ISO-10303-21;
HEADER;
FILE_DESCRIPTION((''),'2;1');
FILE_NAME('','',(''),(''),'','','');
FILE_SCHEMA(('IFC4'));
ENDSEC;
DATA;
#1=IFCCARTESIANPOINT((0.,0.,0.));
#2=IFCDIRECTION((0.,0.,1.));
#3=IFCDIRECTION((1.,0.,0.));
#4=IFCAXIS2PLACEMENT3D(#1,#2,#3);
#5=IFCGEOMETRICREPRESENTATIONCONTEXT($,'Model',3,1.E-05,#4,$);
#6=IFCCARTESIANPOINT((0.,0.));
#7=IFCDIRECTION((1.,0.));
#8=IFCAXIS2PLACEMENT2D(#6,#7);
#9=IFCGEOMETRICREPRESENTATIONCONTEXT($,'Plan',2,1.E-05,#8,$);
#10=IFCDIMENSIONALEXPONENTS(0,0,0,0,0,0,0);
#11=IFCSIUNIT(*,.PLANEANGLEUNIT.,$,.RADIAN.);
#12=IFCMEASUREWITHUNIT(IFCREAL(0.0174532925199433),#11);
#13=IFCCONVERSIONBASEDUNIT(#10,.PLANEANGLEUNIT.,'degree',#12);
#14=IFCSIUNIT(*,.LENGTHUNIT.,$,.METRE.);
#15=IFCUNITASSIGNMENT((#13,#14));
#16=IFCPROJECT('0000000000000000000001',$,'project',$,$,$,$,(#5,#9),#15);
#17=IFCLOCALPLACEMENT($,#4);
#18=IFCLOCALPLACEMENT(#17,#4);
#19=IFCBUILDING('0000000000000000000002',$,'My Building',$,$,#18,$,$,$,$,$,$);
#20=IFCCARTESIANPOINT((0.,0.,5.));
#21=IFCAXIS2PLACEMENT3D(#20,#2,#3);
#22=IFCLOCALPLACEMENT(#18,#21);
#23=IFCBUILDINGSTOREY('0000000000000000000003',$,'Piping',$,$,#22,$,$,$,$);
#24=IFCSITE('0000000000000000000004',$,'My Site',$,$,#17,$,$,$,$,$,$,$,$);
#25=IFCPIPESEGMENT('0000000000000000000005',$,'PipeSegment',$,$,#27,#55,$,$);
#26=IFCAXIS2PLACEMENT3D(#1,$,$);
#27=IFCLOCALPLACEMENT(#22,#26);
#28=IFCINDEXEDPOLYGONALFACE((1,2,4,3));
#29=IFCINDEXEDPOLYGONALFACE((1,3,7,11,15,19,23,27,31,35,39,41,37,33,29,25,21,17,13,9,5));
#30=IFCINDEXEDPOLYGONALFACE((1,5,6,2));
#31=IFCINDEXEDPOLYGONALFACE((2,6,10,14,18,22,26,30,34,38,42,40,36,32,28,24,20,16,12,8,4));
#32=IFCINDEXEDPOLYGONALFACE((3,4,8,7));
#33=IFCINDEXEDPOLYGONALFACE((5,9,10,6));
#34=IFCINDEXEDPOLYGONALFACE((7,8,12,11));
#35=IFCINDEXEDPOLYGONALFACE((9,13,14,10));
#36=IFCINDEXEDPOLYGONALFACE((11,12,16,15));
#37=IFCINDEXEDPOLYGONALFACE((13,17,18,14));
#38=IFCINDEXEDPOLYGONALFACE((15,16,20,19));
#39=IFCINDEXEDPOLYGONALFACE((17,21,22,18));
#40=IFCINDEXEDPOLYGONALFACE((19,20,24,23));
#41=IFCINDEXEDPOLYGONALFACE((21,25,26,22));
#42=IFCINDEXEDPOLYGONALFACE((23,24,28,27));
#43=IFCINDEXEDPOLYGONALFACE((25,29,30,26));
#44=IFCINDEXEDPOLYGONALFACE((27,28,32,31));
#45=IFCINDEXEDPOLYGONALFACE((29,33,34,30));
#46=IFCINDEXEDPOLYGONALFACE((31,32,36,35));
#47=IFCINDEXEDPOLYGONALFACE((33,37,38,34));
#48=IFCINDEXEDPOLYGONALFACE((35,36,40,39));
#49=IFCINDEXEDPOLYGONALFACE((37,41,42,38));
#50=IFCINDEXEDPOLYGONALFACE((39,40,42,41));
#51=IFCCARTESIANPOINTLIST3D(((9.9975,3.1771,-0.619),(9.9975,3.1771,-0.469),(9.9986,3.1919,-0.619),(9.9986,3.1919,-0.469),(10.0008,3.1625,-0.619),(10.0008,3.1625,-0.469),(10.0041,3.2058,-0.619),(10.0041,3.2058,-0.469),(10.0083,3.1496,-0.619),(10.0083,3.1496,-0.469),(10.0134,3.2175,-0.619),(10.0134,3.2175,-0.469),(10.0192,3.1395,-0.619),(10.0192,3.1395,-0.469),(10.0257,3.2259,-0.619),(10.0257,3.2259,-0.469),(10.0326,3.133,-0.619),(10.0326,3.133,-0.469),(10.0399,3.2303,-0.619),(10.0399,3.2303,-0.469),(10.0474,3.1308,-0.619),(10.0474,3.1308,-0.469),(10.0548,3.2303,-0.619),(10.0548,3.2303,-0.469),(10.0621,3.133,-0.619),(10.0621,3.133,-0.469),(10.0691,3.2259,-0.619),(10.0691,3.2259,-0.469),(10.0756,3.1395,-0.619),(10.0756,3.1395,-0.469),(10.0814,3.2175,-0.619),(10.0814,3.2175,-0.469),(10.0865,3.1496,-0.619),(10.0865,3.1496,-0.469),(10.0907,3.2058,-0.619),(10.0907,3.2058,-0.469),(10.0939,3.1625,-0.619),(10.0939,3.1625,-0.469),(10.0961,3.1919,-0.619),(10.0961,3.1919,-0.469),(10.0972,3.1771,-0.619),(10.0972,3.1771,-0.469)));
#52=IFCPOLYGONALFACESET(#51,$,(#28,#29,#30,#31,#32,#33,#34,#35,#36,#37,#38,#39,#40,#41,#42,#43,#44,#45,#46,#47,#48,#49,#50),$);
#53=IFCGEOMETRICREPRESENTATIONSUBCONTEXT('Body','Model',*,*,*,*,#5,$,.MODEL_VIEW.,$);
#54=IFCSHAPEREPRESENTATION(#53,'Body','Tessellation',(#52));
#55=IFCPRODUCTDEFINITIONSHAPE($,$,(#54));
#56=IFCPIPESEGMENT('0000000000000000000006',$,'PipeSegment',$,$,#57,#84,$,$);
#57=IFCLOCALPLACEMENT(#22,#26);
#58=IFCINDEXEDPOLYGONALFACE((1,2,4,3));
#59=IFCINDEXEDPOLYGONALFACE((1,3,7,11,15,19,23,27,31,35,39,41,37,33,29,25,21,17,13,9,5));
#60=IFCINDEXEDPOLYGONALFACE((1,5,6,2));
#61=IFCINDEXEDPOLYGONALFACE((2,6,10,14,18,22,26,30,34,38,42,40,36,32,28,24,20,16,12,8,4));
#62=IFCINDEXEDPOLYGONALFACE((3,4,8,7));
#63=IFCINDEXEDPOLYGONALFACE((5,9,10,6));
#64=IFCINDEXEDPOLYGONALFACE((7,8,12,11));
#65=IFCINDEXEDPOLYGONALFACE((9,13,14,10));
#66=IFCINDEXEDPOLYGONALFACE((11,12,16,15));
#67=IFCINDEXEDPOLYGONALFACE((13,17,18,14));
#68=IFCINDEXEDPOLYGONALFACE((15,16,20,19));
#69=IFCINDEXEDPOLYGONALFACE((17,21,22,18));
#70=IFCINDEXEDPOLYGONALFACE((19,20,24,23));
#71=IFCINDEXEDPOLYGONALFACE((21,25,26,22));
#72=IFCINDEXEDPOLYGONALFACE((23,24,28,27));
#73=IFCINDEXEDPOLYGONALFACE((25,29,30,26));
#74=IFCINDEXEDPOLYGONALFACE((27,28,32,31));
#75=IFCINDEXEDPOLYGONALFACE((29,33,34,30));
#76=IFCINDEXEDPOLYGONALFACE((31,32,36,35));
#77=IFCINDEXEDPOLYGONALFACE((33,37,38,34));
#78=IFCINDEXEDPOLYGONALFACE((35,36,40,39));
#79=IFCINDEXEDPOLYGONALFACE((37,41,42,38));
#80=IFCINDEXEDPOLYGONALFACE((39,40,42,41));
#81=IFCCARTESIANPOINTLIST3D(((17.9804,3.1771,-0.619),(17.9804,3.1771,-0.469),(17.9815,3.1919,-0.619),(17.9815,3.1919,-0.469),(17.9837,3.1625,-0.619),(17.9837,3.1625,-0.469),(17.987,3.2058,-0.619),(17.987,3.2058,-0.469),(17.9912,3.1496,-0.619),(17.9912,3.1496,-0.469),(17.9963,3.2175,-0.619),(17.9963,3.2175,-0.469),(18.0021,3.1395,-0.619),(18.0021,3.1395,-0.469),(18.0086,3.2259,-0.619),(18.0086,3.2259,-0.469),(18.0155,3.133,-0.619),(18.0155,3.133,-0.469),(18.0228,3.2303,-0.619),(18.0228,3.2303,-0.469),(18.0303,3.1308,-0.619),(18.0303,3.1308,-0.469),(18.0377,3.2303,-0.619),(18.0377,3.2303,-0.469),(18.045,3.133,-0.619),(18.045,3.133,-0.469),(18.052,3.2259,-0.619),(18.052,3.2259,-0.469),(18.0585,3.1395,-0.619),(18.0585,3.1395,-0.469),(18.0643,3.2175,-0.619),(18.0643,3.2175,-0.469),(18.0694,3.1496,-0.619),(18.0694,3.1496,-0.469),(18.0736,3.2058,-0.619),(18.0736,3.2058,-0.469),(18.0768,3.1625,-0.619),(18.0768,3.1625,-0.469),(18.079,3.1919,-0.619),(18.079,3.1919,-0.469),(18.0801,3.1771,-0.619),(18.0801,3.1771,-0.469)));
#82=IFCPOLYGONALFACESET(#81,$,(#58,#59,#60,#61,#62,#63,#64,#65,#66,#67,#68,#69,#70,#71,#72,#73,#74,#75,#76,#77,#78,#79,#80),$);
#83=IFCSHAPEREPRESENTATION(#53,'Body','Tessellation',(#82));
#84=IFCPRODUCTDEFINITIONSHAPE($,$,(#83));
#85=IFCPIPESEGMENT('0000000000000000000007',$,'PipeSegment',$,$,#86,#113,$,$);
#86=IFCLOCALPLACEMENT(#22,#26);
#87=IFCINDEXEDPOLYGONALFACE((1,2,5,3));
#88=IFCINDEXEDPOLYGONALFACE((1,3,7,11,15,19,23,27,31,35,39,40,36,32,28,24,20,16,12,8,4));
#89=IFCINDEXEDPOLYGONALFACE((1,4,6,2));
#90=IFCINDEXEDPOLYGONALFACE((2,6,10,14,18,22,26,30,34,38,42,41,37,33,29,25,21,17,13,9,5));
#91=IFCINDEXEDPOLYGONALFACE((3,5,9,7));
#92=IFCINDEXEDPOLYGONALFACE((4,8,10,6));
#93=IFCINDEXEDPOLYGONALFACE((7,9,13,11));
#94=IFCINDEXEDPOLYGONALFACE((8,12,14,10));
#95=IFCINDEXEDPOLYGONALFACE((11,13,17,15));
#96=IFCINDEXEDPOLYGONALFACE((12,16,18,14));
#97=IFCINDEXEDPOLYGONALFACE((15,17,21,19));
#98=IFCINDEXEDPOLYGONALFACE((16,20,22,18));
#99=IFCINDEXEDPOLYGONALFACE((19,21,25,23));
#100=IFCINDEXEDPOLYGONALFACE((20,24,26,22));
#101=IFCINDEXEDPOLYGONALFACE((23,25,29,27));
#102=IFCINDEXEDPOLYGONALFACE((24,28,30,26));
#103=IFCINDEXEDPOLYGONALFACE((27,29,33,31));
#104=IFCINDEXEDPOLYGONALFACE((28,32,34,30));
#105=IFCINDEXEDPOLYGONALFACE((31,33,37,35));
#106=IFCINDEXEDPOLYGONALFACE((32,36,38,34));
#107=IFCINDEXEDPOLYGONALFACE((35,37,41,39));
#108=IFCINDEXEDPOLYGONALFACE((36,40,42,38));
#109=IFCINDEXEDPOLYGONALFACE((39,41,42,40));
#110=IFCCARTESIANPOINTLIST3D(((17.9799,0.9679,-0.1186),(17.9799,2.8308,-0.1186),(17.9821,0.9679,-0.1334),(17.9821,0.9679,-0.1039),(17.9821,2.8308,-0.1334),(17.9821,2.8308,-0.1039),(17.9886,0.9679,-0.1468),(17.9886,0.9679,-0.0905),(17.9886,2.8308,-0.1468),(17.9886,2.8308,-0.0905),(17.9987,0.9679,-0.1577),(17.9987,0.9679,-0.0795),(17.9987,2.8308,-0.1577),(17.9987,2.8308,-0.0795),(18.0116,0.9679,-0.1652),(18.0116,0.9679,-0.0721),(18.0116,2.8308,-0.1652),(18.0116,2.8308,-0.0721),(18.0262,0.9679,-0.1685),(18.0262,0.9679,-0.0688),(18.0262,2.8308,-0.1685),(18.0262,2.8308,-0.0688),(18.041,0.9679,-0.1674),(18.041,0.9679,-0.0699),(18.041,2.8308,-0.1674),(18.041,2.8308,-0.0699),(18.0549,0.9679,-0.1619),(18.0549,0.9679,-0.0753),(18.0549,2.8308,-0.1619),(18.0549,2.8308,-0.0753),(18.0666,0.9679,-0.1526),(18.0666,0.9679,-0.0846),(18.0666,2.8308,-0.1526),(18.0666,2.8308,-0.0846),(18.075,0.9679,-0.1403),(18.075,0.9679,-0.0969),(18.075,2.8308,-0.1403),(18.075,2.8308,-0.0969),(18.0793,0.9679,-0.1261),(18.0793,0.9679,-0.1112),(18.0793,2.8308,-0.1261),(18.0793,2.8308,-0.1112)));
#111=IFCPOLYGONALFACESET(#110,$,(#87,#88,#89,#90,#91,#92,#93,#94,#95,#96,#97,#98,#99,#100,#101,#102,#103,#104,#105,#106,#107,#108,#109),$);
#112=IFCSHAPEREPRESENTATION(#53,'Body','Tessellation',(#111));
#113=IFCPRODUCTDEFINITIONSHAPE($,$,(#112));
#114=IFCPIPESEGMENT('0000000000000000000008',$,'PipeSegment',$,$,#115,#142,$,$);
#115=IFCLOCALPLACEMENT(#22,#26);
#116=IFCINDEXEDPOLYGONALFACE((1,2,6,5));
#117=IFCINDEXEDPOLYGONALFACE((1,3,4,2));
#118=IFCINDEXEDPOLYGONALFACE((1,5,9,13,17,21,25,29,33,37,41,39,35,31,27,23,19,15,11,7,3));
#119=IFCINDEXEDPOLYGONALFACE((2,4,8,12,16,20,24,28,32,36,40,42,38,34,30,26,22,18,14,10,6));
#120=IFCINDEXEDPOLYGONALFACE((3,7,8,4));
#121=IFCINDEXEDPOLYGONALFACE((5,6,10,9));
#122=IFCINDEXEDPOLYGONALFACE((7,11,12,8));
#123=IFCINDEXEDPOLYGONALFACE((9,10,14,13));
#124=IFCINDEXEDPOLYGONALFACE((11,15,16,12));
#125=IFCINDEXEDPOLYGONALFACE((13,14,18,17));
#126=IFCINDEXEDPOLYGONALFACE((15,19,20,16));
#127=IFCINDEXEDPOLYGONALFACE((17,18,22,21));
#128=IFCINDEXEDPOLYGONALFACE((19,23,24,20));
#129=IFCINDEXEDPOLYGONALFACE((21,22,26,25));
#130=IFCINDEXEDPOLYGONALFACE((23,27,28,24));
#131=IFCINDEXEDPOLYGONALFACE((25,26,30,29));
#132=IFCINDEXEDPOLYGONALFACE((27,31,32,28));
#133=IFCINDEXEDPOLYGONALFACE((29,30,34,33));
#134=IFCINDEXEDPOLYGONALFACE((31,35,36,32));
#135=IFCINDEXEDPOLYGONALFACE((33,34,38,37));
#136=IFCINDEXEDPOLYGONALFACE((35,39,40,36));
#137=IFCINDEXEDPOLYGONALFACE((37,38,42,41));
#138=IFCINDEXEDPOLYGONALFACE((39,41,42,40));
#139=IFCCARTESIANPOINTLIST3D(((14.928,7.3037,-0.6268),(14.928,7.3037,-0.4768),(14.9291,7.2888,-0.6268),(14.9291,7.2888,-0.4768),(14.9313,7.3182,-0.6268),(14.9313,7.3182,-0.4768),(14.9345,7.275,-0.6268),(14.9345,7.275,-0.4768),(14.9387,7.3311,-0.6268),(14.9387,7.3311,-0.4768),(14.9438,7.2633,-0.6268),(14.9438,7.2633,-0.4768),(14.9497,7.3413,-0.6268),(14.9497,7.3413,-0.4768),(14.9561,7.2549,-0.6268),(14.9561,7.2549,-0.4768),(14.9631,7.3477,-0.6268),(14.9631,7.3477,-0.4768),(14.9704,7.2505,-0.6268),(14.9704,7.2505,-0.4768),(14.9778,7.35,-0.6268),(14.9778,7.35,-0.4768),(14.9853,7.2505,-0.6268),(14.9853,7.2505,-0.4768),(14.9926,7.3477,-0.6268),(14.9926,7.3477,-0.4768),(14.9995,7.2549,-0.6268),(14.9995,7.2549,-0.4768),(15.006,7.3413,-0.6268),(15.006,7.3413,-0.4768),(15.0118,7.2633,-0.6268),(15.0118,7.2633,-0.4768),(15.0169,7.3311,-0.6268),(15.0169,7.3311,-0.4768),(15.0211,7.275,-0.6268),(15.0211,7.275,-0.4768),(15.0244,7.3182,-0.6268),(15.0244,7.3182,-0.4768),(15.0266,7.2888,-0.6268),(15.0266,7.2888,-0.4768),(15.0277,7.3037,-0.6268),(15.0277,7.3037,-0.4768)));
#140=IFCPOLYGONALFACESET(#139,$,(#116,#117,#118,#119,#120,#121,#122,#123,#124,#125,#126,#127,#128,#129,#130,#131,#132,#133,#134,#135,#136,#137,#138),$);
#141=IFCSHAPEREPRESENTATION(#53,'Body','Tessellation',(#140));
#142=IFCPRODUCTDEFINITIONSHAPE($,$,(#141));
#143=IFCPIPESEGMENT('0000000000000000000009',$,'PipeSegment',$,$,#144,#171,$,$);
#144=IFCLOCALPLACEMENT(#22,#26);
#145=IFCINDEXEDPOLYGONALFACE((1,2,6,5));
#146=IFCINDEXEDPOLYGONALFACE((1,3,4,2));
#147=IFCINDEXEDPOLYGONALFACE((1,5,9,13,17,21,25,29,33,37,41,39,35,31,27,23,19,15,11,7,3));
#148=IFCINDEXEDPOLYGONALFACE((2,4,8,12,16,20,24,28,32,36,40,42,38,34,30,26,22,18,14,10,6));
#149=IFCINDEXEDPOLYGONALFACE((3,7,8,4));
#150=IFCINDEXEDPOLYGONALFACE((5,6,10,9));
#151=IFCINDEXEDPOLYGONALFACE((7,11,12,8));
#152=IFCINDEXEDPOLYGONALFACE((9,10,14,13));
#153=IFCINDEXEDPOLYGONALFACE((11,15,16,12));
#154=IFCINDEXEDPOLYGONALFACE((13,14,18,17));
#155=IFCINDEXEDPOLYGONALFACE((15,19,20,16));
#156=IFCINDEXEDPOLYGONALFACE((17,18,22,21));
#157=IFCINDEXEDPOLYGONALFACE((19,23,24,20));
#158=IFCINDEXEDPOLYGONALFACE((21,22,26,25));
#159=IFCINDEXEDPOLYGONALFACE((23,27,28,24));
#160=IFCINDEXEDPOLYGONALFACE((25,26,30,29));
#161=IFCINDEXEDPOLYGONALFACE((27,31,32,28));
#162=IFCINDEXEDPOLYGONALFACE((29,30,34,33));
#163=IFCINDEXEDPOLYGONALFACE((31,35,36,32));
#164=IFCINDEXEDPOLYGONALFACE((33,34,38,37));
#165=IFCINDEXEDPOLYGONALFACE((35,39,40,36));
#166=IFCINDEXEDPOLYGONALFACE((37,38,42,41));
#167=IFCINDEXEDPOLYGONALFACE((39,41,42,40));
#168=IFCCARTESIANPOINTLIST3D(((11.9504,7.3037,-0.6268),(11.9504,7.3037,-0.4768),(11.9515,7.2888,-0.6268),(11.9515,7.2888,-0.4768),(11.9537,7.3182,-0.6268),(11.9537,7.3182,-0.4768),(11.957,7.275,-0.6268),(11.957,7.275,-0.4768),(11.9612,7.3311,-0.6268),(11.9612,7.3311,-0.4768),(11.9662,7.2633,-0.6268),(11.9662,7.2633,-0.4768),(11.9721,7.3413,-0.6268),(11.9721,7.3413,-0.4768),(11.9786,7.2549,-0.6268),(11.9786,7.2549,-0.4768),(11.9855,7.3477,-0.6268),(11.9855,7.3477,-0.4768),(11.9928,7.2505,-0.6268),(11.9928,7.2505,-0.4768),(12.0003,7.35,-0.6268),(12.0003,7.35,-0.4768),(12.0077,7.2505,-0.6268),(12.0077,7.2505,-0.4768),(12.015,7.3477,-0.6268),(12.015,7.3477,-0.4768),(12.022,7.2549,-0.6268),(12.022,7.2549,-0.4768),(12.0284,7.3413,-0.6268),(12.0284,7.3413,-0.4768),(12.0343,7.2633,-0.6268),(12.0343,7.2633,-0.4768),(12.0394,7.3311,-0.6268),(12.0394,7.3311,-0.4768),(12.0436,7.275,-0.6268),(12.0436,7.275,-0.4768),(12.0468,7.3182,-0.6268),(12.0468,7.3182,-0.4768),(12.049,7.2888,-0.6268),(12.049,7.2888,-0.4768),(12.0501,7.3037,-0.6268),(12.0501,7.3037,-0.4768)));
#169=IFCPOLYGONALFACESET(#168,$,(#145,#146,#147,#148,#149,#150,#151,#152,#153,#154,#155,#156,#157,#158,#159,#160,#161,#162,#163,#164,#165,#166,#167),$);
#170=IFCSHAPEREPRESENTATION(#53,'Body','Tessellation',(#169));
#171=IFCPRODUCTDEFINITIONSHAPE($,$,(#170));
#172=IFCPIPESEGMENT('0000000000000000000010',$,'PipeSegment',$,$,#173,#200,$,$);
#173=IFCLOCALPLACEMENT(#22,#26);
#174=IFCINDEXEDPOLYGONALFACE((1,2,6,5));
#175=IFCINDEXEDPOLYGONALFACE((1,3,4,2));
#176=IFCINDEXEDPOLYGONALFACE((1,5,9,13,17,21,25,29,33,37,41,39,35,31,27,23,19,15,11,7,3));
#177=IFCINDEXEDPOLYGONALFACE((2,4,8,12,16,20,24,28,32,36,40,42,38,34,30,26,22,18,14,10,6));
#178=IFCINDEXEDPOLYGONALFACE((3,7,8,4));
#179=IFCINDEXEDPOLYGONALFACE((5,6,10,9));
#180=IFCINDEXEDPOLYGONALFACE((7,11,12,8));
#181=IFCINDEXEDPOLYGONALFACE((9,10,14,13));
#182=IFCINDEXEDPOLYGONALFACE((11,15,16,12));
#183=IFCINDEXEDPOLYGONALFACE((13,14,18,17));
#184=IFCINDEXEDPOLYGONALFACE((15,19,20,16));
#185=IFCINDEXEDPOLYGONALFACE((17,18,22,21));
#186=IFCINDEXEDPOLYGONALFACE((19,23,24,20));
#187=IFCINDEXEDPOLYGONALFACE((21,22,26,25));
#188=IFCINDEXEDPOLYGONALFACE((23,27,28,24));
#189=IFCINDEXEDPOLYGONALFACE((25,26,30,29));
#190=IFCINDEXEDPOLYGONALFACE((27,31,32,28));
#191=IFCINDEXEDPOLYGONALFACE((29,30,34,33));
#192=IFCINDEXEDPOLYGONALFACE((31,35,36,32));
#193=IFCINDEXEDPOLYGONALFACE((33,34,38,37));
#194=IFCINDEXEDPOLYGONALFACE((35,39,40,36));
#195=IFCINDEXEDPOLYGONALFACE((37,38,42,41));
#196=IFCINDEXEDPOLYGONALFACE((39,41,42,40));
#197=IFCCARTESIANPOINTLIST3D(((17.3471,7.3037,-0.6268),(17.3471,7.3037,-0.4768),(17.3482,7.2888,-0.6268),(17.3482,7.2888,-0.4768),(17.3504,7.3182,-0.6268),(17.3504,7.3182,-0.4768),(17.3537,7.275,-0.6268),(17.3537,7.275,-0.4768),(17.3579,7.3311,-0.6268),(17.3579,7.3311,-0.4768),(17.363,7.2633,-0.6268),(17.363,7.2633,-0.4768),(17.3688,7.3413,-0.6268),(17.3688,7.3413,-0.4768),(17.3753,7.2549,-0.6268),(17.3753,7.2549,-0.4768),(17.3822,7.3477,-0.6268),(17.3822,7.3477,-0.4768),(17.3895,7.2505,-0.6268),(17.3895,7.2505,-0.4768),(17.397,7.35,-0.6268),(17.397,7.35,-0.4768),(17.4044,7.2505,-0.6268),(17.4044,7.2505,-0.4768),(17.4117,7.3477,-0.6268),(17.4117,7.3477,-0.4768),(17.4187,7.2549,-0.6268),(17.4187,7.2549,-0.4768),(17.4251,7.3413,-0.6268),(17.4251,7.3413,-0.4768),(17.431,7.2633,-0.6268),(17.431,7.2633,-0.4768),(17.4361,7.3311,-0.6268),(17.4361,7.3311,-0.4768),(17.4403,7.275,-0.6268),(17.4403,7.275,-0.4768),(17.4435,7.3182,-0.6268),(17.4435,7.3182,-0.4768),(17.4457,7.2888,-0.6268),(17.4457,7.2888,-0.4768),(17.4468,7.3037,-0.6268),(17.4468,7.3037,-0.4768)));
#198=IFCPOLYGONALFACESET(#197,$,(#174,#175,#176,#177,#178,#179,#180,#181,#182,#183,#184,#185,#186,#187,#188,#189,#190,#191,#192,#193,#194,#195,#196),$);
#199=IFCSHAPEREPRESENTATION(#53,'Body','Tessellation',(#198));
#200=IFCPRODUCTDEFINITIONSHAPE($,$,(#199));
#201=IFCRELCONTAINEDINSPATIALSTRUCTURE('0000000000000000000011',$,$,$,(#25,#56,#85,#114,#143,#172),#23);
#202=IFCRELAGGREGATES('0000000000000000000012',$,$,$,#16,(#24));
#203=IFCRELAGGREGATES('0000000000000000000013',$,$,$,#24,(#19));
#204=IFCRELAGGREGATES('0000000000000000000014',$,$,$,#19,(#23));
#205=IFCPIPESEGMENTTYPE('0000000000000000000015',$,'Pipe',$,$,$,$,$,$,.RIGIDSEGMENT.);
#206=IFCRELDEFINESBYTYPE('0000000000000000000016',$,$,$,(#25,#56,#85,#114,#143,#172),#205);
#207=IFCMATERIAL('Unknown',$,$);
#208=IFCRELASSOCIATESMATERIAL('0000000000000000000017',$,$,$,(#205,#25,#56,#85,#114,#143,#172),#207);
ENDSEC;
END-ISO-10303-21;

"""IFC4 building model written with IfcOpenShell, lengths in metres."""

from ifc_helpers import new_model, entity, si_unit, converted_unit, frame, origin_with_axes, origin_2d_with_axis, place, context, subcontext, project, spatial, circle, extrude, material, material_profile, profile_set, profile_usage, type_object, element, save


model = new_model("IFC4")

# Units and contexts
model_context = context("Model", 3, precision=1e-05, world=origin_with_axes())
plan_context = context("Plan", 2, precision=1e-05, world=origin_2d_with_axis())
body_context = subcontext(model_context, "Body", "Model", "MODEL_VIEW")
ifc_project = project(units=[converted_unit("PLANEANGLEUNIT", "degree", entity("IfcReal", 0.0174532925199433), si_unit("PLANEANGLEUNIT", "RADIAN"), dimensions=[0, 0, 0, 0, 0, 0, 0]), si_unit("LENGTHUNIT", "METRE")], contexts=[model_context, plan_context])

# Site, building, storey
site_placement = place(None, origin_with_axes())
site = spatial("IfcSite", under=ifc_project, at=site_placement, Name="My Site")
building_placement = place(site_placement, origin_with_axes())
building = spatial("IfcBuilding", under=site, at=building_placement, Name="My Building")
storey_placement = place(building_placement, frame((0.0, 0.0, 5.0), z_axis=(0.0, 0.0, 1.0), x_axis=(1.0, 0.0, 0.0)))
storey = spatial("IfcBuildingStorey", under=building, at=storey_placement, Name="Piping")

# Pipe segments
ifc_material = material(Name="Unknown")
ifc_material_profile_1 = material_profile(ifc_material, circle(Radius=0.05))
ifc_profile_set_1 = profile_set([ifc_material_profile_1])
pipe_segment_type = type_object("IfcPipeSegmentType", Name="Pipe", PredefinedType="RIGIDSEGMENT", material=ifc_profile_set_1)
ifc_profile_usage_1 = profile_usage(ifc_profile_set_1, cardinal=5)
pipe_segment_1_placement = place(storey_placement, frame((10.0474, 3.1808, -0.469), z_axis=(0.0, 0.0, -1.0), x_axis=(-0.000053, -1.0, 0.0)))
element("IfcPipeSegment", 1, at=pipe_segment_1_placement, inside=storey, type_object=pipe_segment_type, material=ifc_profile_usage_1, Name="PipeSegment", context=body_context, shape_type="SweptSolid", body=[
    extrude(circle(Radius=0.05), origin_with_axes(), (0.0, 0.0, 1.0), 0.15),
])
ifc_profile_usage_2 = profile_usage(ifc_profile_set_1, cardinal=5)
pipe_segment_2_placement = place(storey_placement, frame((18.0303, 3.1808, -0.469), z_axis=(0.0, 0.0, -1.0), x_axis=(-0.000053, -1.0, 0.0)))
element("IfcPipeSegment", 2, at=pipe_segment_2_placement, inside=storey, type_object=pipe_segment_type, material=ifc_profile_usage_2, Name="PipeSegment", context=body_context, shape_type="SweptSolid", body=[
    extrude(circle(Radius=0.05), origin_with_axes(), (0.0, 0.0, 1.0), 0.15),
])
ifc_profile_usage_3 = profile_usage(ifc_profile_set_1, cardinal=5)
pipe_segment_3_placement = place(storey_placement, frame((18.0299, 0.9679, -0.1186), z_axis=(0.0, 1.0, 0.0), x_axis=(-1.0, 0.0, 0.0)))
element("IfcPipeSegment", 3, at=pipe_segment_3_placement, inside=storey, type_object=pipe_segment_type, material=ifc_profile_usage_3, Name="PipeSegment", context=body_context, shape_type="SweptSolid", body=[
    extrude(circle(Radius=0.05), origin_with_axes(), (0.0, 0.0, 1.0), 1.8629),
])
ifc_profile_usage_4 = profile_usage(ifc_profile_set_1, cardinal=5)
pipe_segment_4_placement = place(storey_placement, frame((14.9778, 7.3, -0.4768), z_axis=(0.0, 0.0, -1.0), x_axis=(0.000053, 1.0, 0.0)))
element("IfcPipeSegment", 4, at=pipe_segment_4_placement, inside=storey, type_object=pipe_segment_type, material=ifc_profile_usage_4, Name="PipeSegment", context=body_context, shape_type="SweptSolid", body=[
    extrude(circle(Radius=0.05), origin_with_axes(), (0.0, 0.0, 1.0), 0.15),
])
ifc_profile_usage_5 = profile_usage(ifc_profile_set_1, cardinal=5)
pipe_segment_5_placement = place(storey_placement, frame((12.0003, 7.3, -0.4768), z_axis=(0.0, 0.0, -1.0), x_axis=(0.000053, 1.0, 0.0)))
element("IfcPipeSegment", 5, at=pipe_segment_5_placement, inside=storey, type_object=pipe_segment_type, material=ifc_profile_usage_5, Name="PipeSegment", context=body_context, shape_type="SweptSolid", body=[
    extrude(circle(Radius=0.05), origin_with_axes(), (0.0, 0.0, 1.0), 0.15),
])
ifc_profile_usage_6 = profile_usage(ifc_profile_set_1, cardinal=5)
pipe_segment_6_placement = place(storey_placement, frame((17.397, 7.3, -0.4768), z_axis=(0.0, 0.0, -1.0), x_axis=(0.000053, 1.0, 0.0)))
element("IfcPipeSegment", 6, at=pipe_segment_6_placement, inside=storey, type_object=pipe_segment_type, material=ifc_profile_usage_6, Name="PipeSegment", context=body_context, shape_type="SweptSolid", body=[
    extrude(circle(Radius=0.05), origin_with_axes(), (0.0, 0.0, 1.0), 0.15),
])

save(model, "model.ifc")
